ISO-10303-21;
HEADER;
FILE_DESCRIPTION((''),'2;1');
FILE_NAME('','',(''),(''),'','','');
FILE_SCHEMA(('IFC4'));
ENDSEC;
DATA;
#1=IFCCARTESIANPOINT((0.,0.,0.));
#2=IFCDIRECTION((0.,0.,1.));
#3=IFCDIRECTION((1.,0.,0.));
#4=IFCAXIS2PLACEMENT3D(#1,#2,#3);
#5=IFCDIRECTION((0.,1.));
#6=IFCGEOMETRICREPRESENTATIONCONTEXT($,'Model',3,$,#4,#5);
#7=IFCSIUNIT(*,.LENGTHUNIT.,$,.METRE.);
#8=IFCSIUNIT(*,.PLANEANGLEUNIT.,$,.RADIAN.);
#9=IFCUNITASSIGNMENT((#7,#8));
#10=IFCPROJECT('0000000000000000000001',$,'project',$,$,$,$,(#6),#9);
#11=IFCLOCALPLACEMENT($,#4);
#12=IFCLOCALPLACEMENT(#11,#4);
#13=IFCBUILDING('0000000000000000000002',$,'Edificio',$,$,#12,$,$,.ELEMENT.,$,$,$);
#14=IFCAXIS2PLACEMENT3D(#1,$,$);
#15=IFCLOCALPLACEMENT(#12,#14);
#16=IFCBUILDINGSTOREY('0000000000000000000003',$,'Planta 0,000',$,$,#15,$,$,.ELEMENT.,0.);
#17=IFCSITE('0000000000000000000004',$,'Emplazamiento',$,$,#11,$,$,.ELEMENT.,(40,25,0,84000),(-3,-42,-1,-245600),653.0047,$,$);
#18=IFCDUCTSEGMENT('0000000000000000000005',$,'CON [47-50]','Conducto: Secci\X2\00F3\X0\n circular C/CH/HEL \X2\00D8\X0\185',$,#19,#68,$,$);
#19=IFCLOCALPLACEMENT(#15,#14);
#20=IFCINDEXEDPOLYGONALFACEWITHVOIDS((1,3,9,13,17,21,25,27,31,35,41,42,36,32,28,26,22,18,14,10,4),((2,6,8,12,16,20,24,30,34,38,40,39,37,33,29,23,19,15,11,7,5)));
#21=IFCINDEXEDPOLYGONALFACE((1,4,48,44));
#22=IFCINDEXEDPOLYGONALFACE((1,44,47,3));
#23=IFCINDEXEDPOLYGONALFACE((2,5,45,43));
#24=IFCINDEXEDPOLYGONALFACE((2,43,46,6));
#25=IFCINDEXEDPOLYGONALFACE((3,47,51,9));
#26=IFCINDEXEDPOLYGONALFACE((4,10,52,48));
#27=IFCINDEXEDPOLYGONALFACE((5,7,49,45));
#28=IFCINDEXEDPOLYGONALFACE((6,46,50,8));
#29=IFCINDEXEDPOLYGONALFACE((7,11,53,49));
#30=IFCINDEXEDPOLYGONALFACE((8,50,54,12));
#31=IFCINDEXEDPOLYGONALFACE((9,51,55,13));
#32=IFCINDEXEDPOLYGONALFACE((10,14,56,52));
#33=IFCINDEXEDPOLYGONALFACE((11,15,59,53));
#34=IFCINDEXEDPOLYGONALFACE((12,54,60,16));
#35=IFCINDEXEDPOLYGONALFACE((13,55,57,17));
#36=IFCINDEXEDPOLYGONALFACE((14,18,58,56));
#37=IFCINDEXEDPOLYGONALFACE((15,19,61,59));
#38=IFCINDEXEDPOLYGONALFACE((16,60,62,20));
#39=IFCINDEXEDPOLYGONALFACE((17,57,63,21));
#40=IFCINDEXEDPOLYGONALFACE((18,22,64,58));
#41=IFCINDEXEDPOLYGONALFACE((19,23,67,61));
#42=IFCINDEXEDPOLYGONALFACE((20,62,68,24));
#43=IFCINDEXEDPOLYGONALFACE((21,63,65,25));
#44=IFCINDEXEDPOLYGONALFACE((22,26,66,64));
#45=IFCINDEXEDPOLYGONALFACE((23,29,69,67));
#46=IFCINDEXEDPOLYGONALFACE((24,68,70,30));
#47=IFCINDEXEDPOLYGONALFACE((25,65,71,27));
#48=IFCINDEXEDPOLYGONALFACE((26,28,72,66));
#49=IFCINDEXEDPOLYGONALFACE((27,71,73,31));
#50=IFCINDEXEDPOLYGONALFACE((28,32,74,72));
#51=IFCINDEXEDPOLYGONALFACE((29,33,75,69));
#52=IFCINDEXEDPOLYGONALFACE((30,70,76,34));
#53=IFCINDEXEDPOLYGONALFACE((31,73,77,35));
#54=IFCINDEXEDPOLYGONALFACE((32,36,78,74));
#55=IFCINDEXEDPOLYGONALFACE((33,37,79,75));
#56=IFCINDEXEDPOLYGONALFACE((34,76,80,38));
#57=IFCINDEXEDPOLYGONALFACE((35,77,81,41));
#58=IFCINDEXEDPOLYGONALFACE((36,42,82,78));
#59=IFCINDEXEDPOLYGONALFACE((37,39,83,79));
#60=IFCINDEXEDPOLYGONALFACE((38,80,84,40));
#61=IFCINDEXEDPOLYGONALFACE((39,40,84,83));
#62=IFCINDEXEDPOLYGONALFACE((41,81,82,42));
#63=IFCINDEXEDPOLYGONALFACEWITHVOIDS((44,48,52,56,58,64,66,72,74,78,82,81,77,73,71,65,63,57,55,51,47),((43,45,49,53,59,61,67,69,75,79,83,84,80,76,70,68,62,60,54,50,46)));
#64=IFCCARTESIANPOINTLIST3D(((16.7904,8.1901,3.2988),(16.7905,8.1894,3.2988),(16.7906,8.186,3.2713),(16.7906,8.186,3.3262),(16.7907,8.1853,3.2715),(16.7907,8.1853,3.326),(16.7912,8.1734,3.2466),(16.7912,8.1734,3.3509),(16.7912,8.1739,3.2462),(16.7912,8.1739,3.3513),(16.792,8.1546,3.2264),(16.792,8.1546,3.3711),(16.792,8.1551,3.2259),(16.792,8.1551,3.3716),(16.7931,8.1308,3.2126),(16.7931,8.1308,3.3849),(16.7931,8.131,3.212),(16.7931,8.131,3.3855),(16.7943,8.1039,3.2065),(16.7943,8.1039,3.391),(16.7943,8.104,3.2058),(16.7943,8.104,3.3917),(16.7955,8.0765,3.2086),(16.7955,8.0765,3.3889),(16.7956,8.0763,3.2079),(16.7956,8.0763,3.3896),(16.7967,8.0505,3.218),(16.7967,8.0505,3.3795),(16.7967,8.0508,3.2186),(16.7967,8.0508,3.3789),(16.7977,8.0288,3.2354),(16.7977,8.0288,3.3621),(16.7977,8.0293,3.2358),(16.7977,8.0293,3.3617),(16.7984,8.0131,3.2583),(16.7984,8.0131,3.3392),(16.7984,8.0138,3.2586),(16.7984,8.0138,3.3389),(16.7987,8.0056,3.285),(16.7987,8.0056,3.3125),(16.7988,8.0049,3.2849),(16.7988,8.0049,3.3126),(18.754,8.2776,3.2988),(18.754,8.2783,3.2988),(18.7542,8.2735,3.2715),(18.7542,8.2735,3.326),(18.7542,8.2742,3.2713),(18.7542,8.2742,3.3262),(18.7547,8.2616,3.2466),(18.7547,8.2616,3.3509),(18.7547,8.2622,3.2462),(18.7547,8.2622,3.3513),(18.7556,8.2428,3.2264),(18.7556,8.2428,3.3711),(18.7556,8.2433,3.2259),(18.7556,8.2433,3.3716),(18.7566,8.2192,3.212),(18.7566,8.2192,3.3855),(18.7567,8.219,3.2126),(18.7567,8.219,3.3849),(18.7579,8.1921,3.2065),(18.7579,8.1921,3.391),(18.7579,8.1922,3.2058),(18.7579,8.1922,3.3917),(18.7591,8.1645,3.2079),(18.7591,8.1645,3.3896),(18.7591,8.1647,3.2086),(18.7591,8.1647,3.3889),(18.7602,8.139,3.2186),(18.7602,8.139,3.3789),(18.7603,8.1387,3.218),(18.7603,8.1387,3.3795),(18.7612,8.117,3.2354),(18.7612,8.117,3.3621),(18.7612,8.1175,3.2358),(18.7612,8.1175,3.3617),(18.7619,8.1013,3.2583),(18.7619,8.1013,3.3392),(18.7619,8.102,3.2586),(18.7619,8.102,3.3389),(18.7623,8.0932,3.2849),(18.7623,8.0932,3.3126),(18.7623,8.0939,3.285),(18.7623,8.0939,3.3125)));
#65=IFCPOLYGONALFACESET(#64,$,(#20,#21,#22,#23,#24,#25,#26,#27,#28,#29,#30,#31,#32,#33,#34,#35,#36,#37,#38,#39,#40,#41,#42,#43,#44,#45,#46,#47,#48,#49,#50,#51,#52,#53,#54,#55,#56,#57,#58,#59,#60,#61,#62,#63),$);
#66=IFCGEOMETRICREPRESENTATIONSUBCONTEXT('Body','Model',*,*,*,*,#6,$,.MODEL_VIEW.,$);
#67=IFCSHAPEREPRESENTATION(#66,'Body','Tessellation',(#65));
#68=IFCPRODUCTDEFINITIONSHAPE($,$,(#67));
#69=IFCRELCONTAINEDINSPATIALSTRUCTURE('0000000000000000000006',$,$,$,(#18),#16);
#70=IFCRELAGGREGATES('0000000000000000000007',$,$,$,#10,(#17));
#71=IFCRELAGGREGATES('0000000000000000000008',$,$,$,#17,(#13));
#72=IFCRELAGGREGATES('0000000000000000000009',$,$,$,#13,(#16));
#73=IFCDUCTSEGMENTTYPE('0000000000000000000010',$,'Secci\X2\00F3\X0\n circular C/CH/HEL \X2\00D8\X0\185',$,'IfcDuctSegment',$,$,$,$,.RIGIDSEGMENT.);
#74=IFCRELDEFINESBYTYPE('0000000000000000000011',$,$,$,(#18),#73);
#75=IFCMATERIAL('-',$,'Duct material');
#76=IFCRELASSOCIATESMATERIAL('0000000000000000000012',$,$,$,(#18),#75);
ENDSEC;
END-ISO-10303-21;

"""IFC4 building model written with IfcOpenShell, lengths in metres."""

from ifc_helpers import new_model, si_unit, direction, frame, origin, origin_with_axes, origin_2d_with_axis, place, context, subcontext, project, spatial, hollow_circle, extrude, material, type_object, element, save


model = new_model("IFC4")

# Units and contexts
model_context = context("Model", 3, world=origin_with_axes(), true_north=direction((0.0, 1.0)))
body_context = subcontext(model_context, "Body", "Model", "MODEL_VIEW")
ifc_project = project(units=[si_unit("LENGTHUNIT", "METRE"), si_unit("PLANEANGLEUNIT", "RADIAN")], contexts=[model_context])

# Site, building, storey
site_placement = place(None, origin_with_axes())
site = spatial("IfcSite", under=ifc_project, at=site_placement, Name="Emplazamiento", CompositionType="ELEMENT", RefLatitude=(40, 25, 0, 84000), RefLongitude=(-3, -42, -1, -245600), RefElevation=653.0047)
building_placement = place(site_placement, origin_with_axes())
building = spatial("IfcBuilding", under=site, at=building_placement, Name="Edificio", CompositionType="ELEMENT")
storey_placement = place(building_placement, origin())
storey = spatial("IfcBuildingStorey", under=building, at=storey_placement, Name="Planta 0,000", CompositionType="ELEMENT", Elevation=0.0)

# Shared definitions
ifc_material_1 = material(Name="-", Category="Duct material")

# Duct segment
duct_segment_type_1 = type_object("IfcDuctSegmentType", Name="Sección circular C/CH/HEL Ø185", ApplicableOccurrence="IfcDuctSegment", PredefinedType="RIGIDSEGMENT")
duct_segment_1_placement = place(storey_placement, origin_with_axes())
element("IfcDuctSegment", 1, at=duct_segment_1_placement, inside=storey, type_object=duct_segment_type_1, material=ifc_material_1, Name="CON [47-50]", Description="Conducto: Sección circular C/CH/HEL Ø185", context=body_context, shape_type="SweptSolid", body=[
    extrude(hollow_circle(Radius=0.0932, WallThickness=0.0007, at=origin_2d_with_axis()), frame((16.7946, 8.097, 3.2988), z_axis=(0.998992, 0.044883, 0.0), x_axis=(-0.044883, 0.998992, 0.0)), (0.0, 0.0, 1.0), 1.9655),
])

save(model, "model.ifc")
